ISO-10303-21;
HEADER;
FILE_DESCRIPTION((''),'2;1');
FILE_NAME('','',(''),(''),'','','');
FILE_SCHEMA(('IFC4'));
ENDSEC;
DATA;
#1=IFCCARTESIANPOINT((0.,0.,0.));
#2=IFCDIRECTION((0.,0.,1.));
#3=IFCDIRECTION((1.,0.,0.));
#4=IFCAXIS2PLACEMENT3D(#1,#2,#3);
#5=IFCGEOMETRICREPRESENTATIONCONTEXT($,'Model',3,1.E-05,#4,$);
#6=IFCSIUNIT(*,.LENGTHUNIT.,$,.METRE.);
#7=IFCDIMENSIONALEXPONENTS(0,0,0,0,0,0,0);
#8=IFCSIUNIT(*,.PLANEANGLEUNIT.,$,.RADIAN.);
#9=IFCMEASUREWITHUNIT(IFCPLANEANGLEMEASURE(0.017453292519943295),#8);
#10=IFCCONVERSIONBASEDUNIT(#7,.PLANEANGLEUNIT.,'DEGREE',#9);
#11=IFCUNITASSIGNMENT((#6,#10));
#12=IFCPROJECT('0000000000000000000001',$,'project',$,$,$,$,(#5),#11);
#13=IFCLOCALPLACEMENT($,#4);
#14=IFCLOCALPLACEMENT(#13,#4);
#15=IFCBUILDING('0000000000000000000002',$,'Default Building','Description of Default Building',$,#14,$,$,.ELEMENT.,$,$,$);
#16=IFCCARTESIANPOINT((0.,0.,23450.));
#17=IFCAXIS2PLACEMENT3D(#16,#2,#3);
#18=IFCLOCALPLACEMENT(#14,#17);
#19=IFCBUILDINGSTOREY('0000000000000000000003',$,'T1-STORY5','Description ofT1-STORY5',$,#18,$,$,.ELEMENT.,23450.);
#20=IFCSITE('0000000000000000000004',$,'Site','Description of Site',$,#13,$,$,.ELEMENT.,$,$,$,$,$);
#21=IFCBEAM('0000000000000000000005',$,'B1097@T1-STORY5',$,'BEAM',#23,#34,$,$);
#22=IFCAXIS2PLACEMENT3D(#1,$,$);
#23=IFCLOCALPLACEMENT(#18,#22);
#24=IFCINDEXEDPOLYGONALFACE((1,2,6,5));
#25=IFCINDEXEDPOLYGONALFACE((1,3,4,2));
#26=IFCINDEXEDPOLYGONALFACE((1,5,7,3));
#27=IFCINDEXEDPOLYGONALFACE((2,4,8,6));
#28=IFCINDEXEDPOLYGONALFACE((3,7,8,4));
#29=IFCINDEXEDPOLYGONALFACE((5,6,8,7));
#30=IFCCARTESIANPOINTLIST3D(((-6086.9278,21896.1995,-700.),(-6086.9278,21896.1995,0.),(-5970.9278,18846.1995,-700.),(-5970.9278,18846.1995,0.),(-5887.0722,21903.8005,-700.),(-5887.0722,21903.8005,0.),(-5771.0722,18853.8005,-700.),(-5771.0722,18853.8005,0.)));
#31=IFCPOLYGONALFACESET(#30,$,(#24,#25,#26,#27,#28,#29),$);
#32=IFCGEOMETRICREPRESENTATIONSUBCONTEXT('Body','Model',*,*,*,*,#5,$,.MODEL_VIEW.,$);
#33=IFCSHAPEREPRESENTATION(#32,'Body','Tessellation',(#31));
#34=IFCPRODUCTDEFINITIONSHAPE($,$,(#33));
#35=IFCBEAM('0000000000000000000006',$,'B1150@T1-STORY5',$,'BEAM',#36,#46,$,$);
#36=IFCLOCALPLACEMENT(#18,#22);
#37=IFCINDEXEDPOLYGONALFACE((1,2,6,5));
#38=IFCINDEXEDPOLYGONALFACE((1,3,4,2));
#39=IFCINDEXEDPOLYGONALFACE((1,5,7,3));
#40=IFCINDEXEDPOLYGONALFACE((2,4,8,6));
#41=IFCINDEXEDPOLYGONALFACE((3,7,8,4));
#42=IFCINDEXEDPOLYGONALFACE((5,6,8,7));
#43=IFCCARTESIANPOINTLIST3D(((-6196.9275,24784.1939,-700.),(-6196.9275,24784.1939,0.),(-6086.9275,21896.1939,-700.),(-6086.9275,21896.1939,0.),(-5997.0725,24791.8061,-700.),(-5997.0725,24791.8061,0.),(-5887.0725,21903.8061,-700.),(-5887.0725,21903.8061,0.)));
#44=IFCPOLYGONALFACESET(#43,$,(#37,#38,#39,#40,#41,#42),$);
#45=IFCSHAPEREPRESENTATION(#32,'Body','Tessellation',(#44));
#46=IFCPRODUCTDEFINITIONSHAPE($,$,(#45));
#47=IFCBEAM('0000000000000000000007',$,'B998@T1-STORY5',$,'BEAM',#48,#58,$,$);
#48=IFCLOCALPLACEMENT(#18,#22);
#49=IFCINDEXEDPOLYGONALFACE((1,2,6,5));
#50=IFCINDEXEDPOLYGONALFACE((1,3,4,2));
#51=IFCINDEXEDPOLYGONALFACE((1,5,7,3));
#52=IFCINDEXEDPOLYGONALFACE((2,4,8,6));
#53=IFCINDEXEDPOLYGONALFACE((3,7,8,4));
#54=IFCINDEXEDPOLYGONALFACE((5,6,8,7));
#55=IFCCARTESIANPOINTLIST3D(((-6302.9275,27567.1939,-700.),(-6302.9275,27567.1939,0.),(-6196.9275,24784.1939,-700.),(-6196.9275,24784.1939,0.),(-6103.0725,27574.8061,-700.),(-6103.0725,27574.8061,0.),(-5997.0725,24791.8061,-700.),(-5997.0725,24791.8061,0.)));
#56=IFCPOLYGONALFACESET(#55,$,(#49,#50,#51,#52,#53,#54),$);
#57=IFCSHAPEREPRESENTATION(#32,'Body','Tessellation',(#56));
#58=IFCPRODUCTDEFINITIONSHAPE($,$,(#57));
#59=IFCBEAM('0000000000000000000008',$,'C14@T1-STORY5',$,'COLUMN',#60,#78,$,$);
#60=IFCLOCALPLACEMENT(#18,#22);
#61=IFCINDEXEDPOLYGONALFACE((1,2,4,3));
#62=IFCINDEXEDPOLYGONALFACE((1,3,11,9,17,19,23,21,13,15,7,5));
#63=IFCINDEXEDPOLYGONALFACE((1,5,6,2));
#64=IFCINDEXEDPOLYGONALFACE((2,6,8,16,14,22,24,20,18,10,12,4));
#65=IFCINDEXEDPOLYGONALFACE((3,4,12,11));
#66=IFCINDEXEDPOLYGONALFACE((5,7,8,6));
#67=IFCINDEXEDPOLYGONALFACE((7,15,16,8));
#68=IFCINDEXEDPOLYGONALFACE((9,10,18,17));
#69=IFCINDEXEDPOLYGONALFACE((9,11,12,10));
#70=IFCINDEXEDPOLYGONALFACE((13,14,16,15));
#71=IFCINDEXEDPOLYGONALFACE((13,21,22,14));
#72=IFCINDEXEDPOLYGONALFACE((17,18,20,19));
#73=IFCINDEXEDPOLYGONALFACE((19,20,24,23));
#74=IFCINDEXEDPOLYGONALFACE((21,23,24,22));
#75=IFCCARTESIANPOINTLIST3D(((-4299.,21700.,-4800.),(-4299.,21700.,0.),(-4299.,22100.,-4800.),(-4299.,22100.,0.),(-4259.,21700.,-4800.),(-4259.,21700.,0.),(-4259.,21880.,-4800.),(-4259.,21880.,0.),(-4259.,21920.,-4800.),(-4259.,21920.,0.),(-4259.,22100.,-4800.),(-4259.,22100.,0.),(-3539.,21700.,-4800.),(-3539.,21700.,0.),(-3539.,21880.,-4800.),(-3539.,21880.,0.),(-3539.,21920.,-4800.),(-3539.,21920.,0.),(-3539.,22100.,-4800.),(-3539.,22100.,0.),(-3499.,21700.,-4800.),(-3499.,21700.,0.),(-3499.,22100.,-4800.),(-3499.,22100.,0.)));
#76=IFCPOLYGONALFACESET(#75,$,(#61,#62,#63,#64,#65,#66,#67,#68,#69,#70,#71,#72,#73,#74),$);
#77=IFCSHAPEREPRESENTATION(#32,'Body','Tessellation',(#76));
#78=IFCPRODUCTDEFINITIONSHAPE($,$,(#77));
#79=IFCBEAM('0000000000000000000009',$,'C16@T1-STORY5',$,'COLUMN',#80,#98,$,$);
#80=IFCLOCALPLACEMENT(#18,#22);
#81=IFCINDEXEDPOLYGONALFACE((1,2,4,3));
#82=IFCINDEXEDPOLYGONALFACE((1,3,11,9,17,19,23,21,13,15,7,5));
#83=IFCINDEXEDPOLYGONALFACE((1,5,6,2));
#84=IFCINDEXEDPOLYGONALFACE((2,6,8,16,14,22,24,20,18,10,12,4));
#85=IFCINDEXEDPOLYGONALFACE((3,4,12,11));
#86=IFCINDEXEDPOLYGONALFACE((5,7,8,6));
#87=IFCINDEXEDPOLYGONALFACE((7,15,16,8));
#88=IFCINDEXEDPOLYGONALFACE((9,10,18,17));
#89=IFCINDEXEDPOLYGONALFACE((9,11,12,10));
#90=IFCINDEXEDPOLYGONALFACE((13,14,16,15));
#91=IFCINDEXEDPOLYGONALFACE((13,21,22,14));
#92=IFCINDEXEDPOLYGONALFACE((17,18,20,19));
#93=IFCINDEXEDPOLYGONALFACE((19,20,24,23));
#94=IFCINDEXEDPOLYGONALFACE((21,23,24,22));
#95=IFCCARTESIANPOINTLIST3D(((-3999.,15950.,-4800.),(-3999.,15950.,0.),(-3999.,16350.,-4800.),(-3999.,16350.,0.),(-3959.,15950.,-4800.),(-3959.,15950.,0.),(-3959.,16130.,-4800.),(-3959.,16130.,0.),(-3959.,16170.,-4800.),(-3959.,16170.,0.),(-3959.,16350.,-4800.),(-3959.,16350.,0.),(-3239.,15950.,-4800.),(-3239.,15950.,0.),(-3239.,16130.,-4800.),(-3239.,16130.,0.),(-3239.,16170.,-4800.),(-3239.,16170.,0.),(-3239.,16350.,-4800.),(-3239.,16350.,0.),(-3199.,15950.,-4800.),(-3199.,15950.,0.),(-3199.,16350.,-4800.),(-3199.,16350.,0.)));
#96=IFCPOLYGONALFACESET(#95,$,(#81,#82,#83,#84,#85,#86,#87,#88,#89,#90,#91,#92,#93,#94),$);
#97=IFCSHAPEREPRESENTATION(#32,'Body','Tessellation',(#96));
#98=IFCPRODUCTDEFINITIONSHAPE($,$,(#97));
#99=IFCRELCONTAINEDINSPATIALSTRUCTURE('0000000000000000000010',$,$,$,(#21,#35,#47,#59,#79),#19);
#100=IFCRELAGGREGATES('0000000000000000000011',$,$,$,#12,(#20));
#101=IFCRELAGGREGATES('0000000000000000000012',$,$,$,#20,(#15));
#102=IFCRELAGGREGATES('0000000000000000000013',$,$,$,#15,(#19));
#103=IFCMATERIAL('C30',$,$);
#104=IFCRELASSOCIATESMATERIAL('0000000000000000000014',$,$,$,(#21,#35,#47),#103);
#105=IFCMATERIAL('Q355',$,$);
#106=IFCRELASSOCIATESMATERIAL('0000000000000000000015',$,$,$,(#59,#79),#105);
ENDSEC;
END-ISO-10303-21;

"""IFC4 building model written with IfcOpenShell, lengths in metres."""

from ifc_helpers import new_model, entity, si_unit, converted_unit, frame, origin_with_axes, place, context, subcontext, project, spatial, rectangle, i_section, extrude, material, element, save


model = new_model("IFC4")

# Units and contexts
model_context = context("Model", 3, precision=1e-05, world=origin_with_axes())
body_context = subcontext(model_context, "Body", "Model", "MODEL_VIEW")
ifc_project = project(units=[si_unit("LENGTHUNIT", "METRE"), converted_unit("PLANEANGLEUNIT", "DEGREE", entity("IfcPlaneAngleMeasure", 0.017453292519943295), si_unit("PLANEANGLEUNIT", "RADIAN"), dimensions=[0, 0, 0, 0, 0, 0, 0])], contexts=[model_context])

# Site, building, storey
site_placement = place(None, origin_with_axes())
site = spatial("IfcSite", under=ifc_project, at=site_placement, Name="Site", Description="Description of Site", CompositionType="ELEMENT")
building_placement = place(site_placement, origin_with_axes())
building = spatial("IfcBuilding", under=site, at=building_placement, Name="Default Building", Description="Description of Default Building", CompositionType="ELEMENT")
storey_placement = place(building_placement, frame((0.0, 0.0, 23450.0), z_axis=(0.0, 0.0, 1.0), x_axis=(1.0, 0.0, 0.0)))
storey = spatial("IfcBuildingStorey", under=building, at=storey_placement, Name="T1-STORY5", Description="Description ofT1-STORY5", CompositionType="ELEMENT", Elevation=23450.0)

# Beams
ifc_material_1 = material(Name="C30")
beam_1_placement = place(storey_placement, frame((-5987.0, 21900.0, -350.0), z_axis=(0.038005, -0.999278, 0.0), x_axis=(0.999278, 0.038005, 0.0)))
element("IfcBeam", 1, at=beam_1_placement, inside=storey, material=ifc_material_1, Name="B1097@T1-STORY5", ObjectType="BEAM", context=body_context, shape_type="SweptSolid", body=[
    extrude(rectangle(XDim=200.0, YDim=700.0), origin_with_axes(), (0.0, 0.0, 1.0), 3052.2051),
])
beam_2_placement = place(storey_placement, frame((-6097.0, 24788.0, -350.0), z_axis=(0.038061, -0.999275, 0.0), x_axis=(0.999275, 0.038061, 0.0)))
element("IfcBeam", 2, at=beam_2_placement, inside=storey, material=ifc_material_1, Name="B1150@T1-STORY5", ObjectType="BEAM", context=body_context, shape_type="SweptSolid", body=[
    extrude(rectangle(XDim=200.0, YDim=700.0), origin_with_axes(), (0.0, 0.0, 1.0), 2890.0941),
])
beam_3_placement = place(storey_placement, frame((-6203.0, 27571.0, -350.0), z_axis=(0.038061, -0.999275, 0.0), x_axis=(0.999275, 0.038061, 0.0)))
element("IfcBeam", 3, at=beam_3_placement, inside=storey, material=ifc_material_1, Name="B998@T1-STORY5", ObjectType="BEAM", context=body_context, shape_type="SweptSolid", body=[
    extrude(rectangle(XDim=200.0, YDim=700.0), origin_with_axes(), (0.0, 0.0, 1.0), 2785.018),
])
ifc_material_2 = material(Name="Q355")
beam_4_placement = place(storey_placement, frame((-3899.0, 21900.0, -4800.0), z_axis=(0.0, 0.0, 1.0), x_axis=(0.0, -1.0, 0.0)))
element("IfcBeam", 4, at=beam_4_placement, inside=storey, material=ifc_material_2, Name="C14@T1-STORY5", ObjectType="COLUMN", context=body_context, shape_type="SweptSolid", body=[
    extrude(i_section(OverallWidth=400.0, OverallDepth=800.0, WebThickness=40.0, FlangeThickness=40.0, FilletRadius=0.0), origin_with_axes(), (0.0, 0.0, 1.0), 4800.0),
])
beam_5_placement = place(storey_placement, frame((-3599.0, 16150.0, -4800.0), z_axis=(0.0, 0.0, 1.0), x_axis=(0.0, -1.0, 0.0)))
element("IfcBeam", 5, at=beam_5_placement, inside=storey, material=ifc_material_2, Name="C16@T1-STORY5", ObjectType="COLUMN", context=body_context, shape_type="SweptSolid", body=[
    extrude(i_section(OverallWidth=400.0, OverallDepth=800.0, WebThickness=40.0, FlangeThickness=40.0, FilletRadius=0.0), origin_with_axes(), (0.0, 0.0, 1.0), 4800.0),
])

save(model, "model.ifc")
